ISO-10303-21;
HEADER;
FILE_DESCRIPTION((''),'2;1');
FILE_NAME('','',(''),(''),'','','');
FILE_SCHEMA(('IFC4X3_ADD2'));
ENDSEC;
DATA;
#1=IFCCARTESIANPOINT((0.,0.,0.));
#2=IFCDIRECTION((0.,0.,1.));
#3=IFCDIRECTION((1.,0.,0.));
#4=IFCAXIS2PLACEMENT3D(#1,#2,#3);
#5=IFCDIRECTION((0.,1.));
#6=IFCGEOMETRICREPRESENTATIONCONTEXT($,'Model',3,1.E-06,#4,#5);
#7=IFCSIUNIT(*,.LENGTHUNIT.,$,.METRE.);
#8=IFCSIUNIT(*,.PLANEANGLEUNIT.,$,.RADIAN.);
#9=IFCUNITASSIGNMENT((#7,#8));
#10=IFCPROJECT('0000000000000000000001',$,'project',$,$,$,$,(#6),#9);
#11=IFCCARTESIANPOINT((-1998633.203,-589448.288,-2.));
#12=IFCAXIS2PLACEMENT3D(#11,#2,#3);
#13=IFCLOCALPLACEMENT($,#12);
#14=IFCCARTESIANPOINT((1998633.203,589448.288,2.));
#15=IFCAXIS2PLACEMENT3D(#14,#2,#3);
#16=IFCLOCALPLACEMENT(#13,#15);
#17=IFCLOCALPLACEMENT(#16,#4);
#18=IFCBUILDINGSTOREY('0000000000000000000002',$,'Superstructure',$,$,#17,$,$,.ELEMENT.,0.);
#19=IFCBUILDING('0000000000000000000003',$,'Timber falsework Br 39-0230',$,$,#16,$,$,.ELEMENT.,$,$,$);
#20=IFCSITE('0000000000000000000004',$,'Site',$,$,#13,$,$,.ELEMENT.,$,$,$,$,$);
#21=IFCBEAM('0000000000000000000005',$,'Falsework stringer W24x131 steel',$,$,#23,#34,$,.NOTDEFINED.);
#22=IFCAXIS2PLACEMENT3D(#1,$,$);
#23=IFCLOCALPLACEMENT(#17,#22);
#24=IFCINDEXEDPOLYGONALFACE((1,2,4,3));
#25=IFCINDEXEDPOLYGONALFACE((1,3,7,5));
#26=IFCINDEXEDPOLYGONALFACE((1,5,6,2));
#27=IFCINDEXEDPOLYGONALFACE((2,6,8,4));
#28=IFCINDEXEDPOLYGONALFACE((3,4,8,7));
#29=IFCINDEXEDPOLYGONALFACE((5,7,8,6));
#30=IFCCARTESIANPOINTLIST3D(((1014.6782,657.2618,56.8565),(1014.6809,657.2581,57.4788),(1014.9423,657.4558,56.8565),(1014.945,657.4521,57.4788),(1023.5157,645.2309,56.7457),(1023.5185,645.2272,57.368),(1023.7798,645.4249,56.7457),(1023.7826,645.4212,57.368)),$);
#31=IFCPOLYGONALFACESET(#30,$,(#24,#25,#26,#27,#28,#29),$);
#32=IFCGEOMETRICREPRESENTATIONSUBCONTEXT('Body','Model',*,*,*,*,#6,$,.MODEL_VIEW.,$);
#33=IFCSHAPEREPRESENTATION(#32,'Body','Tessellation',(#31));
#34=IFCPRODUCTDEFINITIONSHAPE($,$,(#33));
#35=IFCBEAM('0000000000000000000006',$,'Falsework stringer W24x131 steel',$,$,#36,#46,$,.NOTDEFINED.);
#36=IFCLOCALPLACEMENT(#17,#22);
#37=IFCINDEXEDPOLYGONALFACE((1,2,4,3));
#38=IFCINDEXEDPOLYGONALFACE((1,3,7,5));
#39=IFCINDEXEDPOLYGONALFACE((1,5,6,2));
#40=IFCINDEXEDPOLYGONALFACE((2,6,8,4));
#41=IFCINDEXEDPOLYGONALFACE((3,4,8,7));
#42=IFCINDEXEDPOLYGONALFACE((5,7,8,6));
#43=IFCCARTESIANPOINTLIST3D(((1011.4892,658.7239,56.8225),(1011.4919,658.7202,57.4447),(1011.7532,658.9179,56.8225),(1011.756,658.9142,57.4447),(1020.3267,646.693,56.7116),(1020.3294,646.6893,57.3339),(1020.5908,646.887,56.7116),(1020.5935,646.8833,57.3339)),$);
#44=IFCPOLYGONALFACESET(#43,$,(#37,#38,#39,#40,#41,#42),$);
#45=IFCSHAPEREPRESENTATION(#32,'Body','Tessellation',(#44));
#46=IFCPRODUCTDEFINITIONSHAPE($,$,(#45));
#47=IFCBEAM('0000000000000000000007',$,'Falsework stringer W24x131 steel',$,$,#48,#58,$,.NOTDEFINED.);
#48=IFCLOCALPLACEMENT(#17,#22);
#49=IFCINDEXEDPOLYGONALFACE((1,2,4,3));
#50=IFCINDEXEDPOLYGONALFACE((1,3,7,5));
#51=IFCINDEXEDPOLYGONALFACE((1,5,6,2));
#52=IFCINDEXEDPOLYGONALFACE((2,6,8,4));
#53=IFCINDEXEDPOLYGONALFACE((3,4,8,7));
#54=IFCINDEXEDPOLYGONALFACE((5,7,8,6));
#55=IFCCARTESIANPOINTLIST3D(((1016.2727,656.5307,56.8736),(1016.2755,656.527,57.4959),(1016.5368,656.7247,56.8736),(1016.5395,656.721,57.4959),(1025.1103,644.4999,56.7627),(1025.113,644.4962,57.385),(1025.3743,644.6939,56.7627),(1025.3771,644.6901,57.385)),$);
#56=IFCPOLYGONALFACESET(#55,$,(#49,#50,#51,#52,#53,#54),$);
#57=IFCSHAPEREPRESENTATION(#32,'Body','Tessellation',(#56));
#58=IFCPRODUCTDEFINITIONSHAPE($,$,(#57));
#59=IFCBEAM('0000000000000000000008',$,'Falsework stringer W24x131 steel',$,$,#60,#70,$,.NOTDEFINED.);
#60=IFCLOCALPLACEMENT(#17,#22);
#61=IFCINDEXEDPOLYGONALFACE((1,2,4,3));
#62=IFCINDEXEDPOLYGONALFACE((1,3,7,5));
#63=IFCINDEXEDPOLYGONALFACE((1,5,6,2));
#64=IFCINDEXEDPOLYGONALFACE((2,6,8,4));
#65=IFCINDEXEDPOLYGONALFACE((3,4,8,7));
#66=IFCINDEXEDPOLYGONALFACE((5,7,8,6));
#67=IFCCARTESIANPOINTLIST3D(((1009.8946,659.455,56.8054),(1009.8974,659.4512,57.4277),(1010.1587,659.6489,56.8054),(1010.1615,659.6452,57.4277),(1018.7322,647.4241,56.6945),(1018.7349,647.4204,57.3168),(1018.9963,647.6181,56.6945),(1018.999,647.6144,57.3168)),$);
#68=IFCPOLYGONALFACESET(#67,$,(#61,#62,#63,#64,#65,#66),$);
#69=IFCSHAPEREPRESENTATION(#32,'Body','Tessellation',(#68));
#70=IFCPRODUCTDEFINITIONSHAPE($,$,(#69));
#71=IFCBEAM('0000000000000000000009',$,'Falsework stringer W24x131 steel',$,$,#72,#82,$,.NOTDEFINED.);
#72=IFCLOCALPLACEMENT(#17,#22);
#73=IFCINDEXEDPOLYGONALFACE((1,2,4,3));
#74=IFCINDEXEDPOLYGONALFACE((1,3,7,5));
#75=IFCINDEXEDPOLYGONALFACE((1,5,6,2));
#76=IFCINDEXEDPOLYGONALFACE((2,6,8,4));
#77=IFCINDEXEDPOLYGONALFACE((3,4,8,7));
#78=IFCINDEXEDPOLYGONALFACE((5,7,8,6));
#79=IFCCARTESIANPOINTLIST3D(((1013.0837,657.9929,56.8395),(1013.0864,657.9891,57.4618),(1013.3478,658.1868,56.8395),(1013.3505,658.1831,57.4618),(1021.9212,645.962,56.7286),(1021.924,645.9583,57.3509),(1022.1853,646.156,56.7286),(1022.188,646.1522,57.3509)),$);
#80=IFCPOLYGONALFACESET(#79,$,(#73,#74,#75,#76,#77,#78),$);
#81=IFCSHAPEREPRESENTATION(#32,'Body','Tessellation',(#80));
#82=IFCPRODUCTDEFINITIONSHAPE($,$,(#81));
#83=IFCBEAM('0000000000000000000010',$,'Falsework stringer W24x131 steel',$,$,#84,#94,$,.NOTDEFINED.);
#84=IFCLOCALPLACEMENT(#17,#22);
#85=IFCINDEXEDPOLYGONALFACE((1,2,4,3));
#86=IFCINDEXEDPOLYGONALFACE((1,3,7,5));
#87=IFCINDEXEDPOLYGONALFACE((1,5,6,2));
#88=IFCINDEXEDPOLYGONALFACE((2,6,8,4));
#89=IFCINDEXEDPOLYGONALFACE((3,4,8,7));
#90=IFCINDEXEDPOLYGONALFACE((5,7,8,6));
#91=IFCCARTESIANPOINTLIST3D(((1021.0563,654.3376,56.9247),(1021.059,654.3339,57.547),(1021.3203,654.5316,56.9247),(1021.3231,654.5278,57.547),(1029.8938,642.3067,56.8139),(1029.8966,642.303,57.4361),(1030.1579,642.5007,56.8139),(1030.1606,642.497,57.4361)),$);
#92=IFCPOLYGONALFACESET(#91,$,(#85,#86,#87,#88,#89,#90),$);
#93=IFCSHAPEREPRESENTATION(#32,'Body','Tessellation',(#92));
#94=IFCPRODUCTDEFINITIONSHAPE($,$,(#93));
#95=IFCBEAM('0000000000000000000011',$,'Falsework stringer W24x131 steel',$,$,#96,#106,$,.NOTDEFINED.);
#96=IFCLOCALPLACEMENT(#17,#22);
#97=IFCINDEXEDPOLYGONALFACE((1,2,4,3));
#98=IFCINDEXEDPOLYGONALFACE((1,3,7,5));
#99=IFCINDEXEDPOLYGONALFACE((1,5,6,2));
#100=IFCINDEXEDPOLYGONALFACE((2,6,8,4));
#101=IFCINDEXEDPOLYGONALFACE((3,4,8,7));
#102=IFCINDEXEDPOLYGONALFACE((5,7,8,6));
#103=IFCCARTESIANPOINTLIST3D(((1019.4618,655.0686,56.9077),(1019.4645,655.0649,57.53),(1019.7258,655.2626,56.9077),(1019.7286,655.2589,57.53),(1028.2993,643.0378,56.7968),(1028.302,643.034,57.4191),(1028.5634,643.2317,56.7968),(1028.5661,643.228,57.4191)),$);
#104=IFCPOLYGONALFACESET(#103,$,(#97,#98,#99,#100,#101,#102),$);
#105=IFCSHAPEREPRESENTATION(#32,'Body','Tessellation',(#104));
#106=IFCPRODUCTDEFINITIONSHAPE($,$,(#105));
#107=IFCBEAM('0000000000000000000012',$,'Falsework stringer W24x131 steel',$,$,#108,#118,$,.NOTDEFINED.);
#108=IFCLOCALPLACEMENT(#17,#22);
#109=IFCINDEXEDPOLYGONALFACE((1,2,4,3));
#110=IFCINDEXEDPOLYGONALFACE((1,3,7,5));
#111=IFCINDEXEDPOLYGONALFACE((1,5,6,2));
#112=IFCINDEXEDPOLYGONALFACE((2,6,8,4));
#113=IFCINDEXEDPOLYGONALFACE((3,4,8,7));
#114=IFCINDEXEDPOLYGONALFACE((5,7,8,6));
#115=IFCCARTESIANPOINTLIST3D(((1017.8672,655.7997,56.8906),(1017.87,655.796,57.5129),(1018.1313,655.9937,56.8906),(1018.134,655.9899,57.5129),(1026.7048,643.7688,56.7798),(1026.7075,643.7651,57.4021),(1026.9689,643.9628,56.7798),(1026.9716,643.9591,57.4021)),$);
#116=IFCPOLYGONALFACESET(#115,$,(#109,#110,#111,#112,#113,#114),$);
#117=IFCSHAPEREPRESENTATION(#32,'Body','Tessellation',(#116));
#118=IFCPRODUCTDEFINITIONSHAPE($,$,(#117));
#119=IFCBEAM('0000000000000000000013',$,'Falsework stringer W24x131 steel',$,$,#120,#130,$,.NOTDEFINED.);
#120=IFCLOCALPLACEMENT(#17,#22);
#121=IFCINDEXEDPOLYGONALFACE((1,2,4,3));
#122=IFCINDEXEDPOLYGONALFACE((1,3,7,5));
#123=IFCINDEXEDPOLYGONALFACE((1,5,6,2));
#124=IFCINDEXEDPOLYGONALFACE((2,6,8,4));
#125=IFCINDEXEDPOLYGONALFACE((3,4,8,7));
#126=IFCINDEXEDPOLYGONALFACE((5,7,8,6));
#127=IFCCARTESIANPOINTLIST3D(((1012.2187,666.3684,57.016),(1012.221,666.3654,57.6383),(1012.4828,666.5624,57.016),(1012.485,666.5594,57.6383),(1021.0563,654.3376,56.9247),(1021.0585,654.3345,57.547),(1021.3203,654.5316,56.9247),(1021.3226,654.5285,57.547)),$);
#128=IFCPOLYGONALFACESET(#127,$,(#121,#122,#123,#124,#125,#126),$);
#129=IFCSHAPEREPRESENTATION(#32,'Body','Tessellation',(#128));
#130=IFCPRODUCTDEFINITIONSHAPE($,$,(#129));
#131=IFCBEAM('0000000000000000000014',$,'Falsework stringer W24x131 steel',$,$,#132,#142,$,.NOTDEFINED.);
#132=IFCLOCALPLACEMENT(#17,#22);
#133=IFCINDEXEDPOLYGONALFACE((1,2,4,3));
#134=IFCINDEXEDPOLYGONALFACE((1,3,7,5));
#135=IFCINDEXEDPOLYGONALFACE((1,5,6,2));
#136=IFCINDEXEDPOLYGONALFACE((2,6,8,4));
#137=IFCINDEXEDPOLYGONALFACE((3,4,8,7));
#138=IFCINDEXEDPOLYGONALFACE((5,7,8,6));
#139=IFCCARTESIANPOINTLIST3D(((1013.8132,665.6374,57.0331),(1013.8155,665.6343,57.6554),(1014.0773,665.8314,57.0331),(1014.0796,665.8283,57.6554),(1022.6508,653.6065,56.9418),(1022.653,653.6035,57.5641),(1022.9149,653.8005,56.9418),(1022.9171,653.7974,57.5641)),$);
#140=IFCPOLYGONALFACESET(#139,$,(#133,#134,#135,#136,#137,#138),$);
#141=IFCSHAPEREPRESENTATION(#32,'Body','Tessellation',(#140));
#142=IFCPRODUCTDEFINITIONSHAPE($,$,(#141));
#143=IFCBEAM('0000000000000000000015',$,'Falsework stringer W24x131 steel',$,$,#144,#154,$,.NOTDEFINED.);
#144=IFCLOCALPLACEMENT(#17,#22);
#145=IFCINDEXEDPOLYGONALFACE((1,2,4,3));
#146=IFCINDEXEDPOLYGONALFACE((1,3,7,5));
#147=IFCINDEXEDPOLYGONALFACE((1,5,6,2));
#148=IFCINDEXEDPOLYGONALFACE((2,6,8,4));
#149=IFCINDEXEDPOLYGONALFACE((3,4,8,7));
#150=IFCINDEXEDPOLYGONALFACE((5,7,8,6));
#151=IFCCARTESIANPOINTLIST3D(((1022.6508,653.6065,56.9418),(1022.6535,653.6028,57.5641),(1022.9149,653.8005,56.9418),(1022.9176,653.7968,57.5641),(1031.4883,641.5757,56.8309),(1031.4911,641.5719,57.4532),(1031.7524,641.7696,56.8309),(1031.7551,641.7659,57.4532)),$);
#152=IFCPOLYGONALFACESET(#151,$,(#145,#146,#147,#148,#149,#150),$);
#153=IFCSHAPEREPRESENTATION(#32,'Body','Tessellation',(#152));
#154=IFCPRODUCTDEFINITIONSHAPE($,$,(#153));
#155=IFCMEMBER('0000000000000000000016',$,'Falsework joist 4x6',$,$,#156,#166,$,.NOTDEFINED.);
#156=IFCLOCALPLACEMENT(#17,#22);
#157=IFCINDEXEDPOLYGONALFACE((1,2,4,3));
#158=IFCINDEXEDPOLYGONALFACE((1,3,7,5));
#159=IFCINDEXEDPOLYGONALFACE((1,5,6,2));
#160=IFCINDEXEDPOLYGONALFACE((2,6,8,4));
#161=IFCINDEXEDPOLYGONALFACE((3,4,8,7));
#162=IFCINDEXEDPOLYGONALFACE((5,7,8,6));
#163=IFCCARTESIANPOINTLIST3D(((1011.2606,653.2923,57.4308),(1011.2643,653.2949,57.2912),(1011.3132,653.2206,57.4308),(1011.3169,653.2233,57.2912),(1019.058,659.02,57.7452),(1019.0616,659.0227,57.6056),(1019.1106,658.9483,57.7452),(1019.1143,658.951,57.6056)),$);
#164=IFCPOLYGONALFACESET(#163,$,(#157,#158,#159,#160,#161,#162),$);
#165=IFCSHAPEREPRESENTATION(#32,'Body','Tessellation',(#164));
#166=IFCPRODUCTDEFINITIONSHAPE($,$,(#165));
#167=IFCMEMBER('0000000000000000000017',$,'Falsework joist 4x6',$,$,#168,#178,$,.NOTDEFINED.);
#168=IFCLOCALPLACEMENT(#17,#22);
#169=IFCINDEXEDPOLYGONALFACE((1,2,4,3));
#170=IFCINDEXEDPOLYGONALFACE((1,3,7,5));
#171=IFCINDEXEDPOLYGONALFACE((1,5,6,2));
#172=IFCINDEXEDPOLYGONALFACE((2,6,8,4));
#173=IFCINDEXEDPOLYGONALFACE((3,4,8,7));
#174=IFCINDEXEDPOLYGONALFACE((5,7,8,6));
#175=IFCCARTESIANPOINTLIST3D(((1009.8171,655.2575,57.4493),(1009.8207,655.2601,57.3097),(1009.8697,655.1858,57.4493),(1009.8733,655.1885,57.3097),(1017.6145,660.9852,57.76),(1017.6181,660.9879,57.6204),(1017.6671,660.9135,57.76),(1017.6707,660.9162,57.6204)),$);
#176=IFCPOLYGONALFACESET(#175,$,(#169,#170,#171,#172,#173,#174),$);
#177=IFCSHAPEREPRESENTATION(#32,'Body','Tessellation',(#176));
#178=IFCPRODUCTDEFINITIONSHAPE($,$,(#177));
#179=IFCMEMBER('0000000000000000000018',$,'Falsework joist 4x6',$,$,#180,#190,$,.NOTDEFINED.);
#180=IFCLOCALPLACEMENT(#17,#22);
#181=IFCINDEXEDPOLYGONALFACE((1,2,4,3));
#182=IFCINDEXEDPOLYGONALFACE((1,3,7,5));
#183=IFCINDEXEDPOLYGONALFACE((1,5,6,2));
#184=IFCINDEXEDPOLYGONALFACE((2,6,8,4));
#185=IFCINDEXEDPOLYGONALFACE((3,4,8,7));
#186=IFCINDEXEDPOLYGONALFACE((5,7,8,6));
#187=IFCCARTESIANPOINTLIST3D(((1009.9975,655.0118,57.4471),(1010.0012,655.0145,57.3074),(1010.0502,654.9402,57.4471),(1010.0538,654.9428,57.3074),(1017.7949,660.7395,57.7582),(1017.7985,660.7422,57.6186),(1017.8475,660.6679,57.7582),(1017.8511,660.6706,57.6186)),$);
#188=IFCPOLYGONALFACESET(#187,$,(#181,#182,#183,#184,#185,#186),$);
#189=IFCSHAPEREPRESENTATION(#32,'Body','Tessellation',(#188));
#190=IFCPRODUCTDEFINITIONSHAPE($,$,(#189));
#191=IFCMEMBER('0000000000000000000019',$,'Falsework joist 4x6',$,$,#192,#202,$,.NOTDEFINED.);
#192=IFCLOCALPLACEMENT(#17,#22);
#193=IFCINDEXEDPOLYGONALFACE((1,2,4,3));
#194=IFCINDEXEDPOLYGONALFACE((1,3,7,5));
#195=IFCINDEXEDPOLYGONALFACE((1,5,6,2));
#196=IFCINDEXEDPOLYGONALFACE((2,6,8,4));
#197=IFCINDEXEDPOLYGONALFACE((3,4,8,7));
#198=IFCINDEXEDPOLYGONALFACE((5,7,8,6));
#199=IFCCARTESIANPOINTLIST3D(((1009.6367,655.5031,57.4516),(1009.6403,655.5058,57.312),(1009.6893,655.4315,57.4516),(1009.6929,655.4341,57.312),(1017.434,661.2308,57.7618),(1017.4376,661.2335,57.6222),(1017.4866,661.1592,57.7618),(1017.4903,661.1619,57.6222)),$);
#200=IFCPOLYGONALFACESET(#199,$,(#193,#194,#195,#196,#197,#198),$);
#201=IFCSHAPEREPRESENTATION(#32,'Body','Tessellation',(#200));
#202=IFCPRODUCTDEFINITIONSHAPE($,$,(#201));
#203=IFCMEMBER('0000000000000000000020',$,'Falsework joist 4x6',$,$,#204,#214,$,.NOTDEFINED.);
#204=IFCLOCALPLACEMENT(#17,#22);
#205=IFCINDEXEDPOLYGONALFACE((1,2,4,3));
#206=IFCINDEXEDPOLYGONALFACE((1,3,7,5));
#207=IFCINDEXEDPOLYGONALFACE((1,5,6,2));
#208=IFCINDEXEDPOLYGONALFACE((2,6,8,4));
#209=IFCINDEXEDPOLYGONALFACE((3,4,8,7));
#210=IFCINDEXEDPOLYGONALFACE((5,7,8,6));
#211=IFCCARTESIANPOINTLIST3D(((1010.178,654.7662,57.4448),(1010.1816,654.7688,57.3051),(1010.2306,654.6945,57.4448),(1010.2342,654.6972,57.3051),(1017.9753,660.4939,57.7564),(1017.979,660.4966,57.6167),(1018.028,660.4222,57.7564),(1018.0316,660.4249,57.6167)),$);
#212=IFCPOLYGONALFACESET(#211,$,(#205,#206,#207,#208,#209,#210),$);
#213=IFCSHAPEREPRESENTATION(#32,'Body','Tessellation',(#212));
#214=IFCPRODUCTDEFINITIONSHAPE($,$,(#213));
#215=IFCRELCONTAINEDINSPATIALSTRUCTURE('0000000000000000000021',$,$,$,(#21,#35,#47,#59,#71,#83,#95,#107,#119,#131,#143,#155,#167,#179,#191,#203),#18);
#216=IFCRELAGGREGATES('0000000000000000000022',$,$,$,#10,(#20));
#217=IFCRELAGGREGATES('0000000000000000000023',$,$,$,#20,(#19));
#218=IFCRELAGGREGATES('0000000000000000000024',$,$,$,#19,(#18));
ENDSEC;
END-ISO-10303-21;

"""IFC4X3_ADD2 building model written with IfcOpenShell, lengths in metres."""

from ifc_helpers import new_model, si_unit, direction, frame, frame_2d, origin, origin_with_axes, place, context, subcontext, project, spatial, rectangle, extrude, element, save


model = new_model("IFC4X3_ADD2")

# Units and contexts
model_context = context("Model", 3, precision=1e-06, world=origin_with_axes(), true_north=direction((0.0, 1.0)))
body_context = subcontext(model_context, "Body", "Model", "MODEL_VIEW")
ifc_project = project(units=[si_unit("LENGTHUNIT", "METRE"), si_unit("PLANEANGLEUNIT", "RADIAN")], contexts=[model_context])

# Site, building, storey
site_placement = place(None, frame((-1998633.203, -589448.288, -2.0), z_axis=(0.0, 0.0, 1.0), x_axis=(1.0, 0.0, 0.0)))
site = spatial("IfcSite", under=ifc_project, at=site_placement, Name="Site", CompositionType="ELEMENT")
building_placement = place(site_placement, frame((1998633.203, 589448.288, 2.0), z_axis=(0.0, 0.0, 1.0), x_axis=(1.0, 0.0, 0.0)))
building = spatial("IfcBuilding", under=site, at=building_placement, Name="Timber falsework Br 39-0230", CompositionType="ELEMENT")
storey_placement = place(building_placement, origin_with_axes())
storey = spatial("IfcBuildingStorey", under=building, at=storey_placement, Name="Superstructure", CompositionType="ELEMENT", Elevation=0.0)

# Beams
beam_1_placement = place(storey_placement, frame((1014.8102, 657.3588, 56.8565), z_axis=(0.591997, -0.805906, -0.007427), x_axis=(0.805928, 0.592013, 0.0)))
element("IfcBeam", 1, at=beam_1_placement, inside=storey, Name="Falsework stringer W24x131 steel", PredefinedType="NOTDEFINED", context=body_context, shape_type="SweptSolid", body=[
    extrude(rectangle(XDim=0.3277, YDim=0.6223, at=frame_2d((0.0, 0.3111))), origin(), (0.0, 0.0, 1.0), 14.9284),
])
for number, where, z_axis, x_axis, name in (
    (2, (1011.6212, 658.8209, 56.8225), (0.591997, -0.805906, -0.007427), (0.805928, 0.592013, 0.0), "Falsework stringer W24x131 steel"),
    (3, (1016.4048, 656.6277, 56.8736), (0.591997, -0.805906, -0.007427), (0.805928, 0.592013, 0.0), "Falsework stringer W24x131 steel"),
    (4, (1010.0267, 659.552, 56.8054), (0.591997, -0.805906, -0.007427), (0.805928, 0.592013, 0.0), "Falsework stringer W24x131 steel"),
):
    element("IfcBeam", number, at=place(storey_placement, frame(where, z_axis=z_axis, x_axis=x_axis)), inside=storey, Name=name, PredefinedType="NOTDEFINED", context=body_context, shape_type="SweptSolid", body=[
        extrude(rectangle(XDim=0.3277, YDim=0.6223, at=frame_2d((0.0, 0.3111))), origin(), (0.0, 0.0, 1.0), 14.9284),
    ])
beam_2_placement = place(storey_placement, frame((1013.2157, 658.0898, 56.8395), z_axis=(0.591997, -0.805906, -0.007427), x_axis=(0.805928, 0.592013, 0.0)))
element("IfcBeam", 5, at=beam_2_placement, inside=storey, Name="Falsework stringer W24x131 steel", PredefinedType="NOTDEFINED", context=body_context, shape_type="SweptSolid", body=[
    extrude(rectangle(XDim=0.3277, YDim=0.6223, at=frame_2d((0.0, 0.3111))), origin(), (0.0, 0.0, 1.0), 14.9284),
])
for number, where, z_axis, x_axis, name in (
    (6, (1021.1883, 654.4346, 56.9247), (0.591997, -0.805906, -0.007427), (0.805928, 0.592013, 0.0), "Falsework stringer W24x131 steel"),
    (7, (1019.5938, 655.1656, 56.9077), (0.591997, -0.805906, -0.007427), (0.805928, 0.592013, 0.0), "Falsework stringer W24x131 steel"),
    (8, (1017.9993, 655.8967, 56.8906), (0.591997, -0.805906, -0.007427), (0.805928, 0.592013, 0.0), "Falsework stringer W24x131 steel"),
):
    element("IfcBeam", number, at=place(storey_placement, frame(where, z_axis=z_axis, x_axis=x_axis)), inside=storey, Name=name, PredefinedType="NOTDEFINED", context=body_context, shape_type="SweptSolid", body=[
        extrude(rectangle(XDim=0.3277, YDim=0.6223, at=frame_2d((0.0, 0.3111))), origin(), (0.0, 0.0, 1.0), 14.9284),
    ])
for number, where, z_axis, x_axis, name in (
    (9, (1012.3508, 666.4654, 57.016), (0.592002, -0.805913, -0.006116), (0.805928, 0.592013, 0.0), "Falsework stringer W24x131 steel"),
    (10, (1013.9453, 665.7344, 57.0331), (0.592002, -0.805913, -0.006116), (0.805928, 0.592013, 0.0), "Falsework stringer W24x131 steel"),
):
    element("IfcBeam", number, at=place(storey_placement, frame(where, z_axis=z_axis, x_axis=x_axis)), inside=storey, Name=name, PredefinedType="NOTDEFINED", context=body_context, shape_type="SweptSolid", body=[
        extrude(rectangle(XDim=0.3277, YDim=0.6223, at=frame_2d((0.0, 0.3111))), origin(), (0.0, 0.0, 1.0), 14.9282),
    ])
beam_3_placement = place(storey_placement, frame((1022.7828, 653.7035, 56.9418), z_axis=(0.591997, -0.805906, -0.007427), x_axis=(0.805928, 0.592013, 0.0)))
element("IfcBeam", 11, at=beam_3_placement, inside=storey, Name="Falsework stringer W24x131 steel", PredefinedType="NOTDEFINED", context=body_context, shape_type="SweptSolid", body=[
    extrude(rectangle(XDim=0.3277, YDim=0.6223, at=frame_2d((0.0, 0.3111))), origin(), (0.0, 0.0, 1.0), 14.9284),
])

# Members
member_1_placement = place(storey_placement, frame((1011.2906, 653.2591, 57.2912), z_axis=(0.805503, 0.591701, 0.032478), x_axis=(-0.592013, 0.805928, 0.0)))
element("IfcMember", 12, at=member_1_placement, inside=storey, Name="Falsework joist 4x6", PredefinedType="NOTDEFINED", context=body_context, shape_type="SweptSolid", body=[
    extrude(rectangle(XDim=0.0889, YDim=0.1397, at=frame_2d((0.0, 0.0698))), origin(), (0.0, 0.0, 1.0), 9.6801),
])
member_2_placement = place(storey_placement, frame((1009.847, 655.2243, 57.3097), z_axis=(0.805513, 0.591708, 0.032094), x_axis=(-0.592013, 0.805928, 0.0)))
element("IfcMember", 13, at=member_2_placement, inside=storey, Name="Falsework joist 4x6", PredefinedType="NOTDEFINED", context=body_context, shape_type="SweptSolid", body=[
    extrude(rectangle(XDim=0.0889, YDim=0.1397, at=frame_2d((0.0, 0.0698))), origin(), (0.0, 0.0, 1.0), 9.68),
])
member_3_placement = place(storey_placement, frame((1010.0275, 654.9787, 57.3074), z_axis=(0.805512, 0.591707, 0.032142), x_axis=(-0.592013, 0.805928, 0.0)))
element("IfcMember", 14, at=member_3_placement, inside=storey, Name="Falsework joist 4x6", PredefinedType="NOTDEFINED", context=body_context, shape_type="SweptSolid", body=[
    extrude(rectangle(XDim=0.0889, YDim=0.1397, at=frame_2d((0.0, 0.0698))), origin(), (0.0, 0.0, 1.0), 9.68),
])
member_4_placement = place(storey_placement, frame((1009.6666, 655.4699, 57.312), z_axis=(0.805514, 0.591709, 0.032046), x_axis=(-0.592013, 0.805928, 0.0)))
element("IfcMember", 15, at=member_4_placement, inside=storey, Name="Falsework joist 4x6", PredefinedType="NOTDEFINED", context=body_context, shape_type="SweptSolid", body=[
    extrude(rectangle(XDim=0.0889, YDim=0.1397, at=frame_2d((0.0, 0.0698))), origin(), (0.0, 0.0, 1.0), 9.68),
])
member_5_placement = place(storey_placement, frame((1010.2079, 654.733, 57.3051), z_axis=(0.805511, 0.591706, 0.03219), x_axis=(-0.592013, 0.805928, 0.0)))
element("IfcMember", 16, at=member_5_placement, inside=storey, Name="Falsework joist 4x6", PredefinedType="NOTDEFINED", context=body_context, shape_type="SweptSolid", body=[
    extrude(rectangle(XDim=0.0889, YDim=0.1397, at=frame_2d((0.0, 0.0698))), origin(), (0.0, 0.0, 1.0), 9.68),
])

save(model, "model.ifc")
